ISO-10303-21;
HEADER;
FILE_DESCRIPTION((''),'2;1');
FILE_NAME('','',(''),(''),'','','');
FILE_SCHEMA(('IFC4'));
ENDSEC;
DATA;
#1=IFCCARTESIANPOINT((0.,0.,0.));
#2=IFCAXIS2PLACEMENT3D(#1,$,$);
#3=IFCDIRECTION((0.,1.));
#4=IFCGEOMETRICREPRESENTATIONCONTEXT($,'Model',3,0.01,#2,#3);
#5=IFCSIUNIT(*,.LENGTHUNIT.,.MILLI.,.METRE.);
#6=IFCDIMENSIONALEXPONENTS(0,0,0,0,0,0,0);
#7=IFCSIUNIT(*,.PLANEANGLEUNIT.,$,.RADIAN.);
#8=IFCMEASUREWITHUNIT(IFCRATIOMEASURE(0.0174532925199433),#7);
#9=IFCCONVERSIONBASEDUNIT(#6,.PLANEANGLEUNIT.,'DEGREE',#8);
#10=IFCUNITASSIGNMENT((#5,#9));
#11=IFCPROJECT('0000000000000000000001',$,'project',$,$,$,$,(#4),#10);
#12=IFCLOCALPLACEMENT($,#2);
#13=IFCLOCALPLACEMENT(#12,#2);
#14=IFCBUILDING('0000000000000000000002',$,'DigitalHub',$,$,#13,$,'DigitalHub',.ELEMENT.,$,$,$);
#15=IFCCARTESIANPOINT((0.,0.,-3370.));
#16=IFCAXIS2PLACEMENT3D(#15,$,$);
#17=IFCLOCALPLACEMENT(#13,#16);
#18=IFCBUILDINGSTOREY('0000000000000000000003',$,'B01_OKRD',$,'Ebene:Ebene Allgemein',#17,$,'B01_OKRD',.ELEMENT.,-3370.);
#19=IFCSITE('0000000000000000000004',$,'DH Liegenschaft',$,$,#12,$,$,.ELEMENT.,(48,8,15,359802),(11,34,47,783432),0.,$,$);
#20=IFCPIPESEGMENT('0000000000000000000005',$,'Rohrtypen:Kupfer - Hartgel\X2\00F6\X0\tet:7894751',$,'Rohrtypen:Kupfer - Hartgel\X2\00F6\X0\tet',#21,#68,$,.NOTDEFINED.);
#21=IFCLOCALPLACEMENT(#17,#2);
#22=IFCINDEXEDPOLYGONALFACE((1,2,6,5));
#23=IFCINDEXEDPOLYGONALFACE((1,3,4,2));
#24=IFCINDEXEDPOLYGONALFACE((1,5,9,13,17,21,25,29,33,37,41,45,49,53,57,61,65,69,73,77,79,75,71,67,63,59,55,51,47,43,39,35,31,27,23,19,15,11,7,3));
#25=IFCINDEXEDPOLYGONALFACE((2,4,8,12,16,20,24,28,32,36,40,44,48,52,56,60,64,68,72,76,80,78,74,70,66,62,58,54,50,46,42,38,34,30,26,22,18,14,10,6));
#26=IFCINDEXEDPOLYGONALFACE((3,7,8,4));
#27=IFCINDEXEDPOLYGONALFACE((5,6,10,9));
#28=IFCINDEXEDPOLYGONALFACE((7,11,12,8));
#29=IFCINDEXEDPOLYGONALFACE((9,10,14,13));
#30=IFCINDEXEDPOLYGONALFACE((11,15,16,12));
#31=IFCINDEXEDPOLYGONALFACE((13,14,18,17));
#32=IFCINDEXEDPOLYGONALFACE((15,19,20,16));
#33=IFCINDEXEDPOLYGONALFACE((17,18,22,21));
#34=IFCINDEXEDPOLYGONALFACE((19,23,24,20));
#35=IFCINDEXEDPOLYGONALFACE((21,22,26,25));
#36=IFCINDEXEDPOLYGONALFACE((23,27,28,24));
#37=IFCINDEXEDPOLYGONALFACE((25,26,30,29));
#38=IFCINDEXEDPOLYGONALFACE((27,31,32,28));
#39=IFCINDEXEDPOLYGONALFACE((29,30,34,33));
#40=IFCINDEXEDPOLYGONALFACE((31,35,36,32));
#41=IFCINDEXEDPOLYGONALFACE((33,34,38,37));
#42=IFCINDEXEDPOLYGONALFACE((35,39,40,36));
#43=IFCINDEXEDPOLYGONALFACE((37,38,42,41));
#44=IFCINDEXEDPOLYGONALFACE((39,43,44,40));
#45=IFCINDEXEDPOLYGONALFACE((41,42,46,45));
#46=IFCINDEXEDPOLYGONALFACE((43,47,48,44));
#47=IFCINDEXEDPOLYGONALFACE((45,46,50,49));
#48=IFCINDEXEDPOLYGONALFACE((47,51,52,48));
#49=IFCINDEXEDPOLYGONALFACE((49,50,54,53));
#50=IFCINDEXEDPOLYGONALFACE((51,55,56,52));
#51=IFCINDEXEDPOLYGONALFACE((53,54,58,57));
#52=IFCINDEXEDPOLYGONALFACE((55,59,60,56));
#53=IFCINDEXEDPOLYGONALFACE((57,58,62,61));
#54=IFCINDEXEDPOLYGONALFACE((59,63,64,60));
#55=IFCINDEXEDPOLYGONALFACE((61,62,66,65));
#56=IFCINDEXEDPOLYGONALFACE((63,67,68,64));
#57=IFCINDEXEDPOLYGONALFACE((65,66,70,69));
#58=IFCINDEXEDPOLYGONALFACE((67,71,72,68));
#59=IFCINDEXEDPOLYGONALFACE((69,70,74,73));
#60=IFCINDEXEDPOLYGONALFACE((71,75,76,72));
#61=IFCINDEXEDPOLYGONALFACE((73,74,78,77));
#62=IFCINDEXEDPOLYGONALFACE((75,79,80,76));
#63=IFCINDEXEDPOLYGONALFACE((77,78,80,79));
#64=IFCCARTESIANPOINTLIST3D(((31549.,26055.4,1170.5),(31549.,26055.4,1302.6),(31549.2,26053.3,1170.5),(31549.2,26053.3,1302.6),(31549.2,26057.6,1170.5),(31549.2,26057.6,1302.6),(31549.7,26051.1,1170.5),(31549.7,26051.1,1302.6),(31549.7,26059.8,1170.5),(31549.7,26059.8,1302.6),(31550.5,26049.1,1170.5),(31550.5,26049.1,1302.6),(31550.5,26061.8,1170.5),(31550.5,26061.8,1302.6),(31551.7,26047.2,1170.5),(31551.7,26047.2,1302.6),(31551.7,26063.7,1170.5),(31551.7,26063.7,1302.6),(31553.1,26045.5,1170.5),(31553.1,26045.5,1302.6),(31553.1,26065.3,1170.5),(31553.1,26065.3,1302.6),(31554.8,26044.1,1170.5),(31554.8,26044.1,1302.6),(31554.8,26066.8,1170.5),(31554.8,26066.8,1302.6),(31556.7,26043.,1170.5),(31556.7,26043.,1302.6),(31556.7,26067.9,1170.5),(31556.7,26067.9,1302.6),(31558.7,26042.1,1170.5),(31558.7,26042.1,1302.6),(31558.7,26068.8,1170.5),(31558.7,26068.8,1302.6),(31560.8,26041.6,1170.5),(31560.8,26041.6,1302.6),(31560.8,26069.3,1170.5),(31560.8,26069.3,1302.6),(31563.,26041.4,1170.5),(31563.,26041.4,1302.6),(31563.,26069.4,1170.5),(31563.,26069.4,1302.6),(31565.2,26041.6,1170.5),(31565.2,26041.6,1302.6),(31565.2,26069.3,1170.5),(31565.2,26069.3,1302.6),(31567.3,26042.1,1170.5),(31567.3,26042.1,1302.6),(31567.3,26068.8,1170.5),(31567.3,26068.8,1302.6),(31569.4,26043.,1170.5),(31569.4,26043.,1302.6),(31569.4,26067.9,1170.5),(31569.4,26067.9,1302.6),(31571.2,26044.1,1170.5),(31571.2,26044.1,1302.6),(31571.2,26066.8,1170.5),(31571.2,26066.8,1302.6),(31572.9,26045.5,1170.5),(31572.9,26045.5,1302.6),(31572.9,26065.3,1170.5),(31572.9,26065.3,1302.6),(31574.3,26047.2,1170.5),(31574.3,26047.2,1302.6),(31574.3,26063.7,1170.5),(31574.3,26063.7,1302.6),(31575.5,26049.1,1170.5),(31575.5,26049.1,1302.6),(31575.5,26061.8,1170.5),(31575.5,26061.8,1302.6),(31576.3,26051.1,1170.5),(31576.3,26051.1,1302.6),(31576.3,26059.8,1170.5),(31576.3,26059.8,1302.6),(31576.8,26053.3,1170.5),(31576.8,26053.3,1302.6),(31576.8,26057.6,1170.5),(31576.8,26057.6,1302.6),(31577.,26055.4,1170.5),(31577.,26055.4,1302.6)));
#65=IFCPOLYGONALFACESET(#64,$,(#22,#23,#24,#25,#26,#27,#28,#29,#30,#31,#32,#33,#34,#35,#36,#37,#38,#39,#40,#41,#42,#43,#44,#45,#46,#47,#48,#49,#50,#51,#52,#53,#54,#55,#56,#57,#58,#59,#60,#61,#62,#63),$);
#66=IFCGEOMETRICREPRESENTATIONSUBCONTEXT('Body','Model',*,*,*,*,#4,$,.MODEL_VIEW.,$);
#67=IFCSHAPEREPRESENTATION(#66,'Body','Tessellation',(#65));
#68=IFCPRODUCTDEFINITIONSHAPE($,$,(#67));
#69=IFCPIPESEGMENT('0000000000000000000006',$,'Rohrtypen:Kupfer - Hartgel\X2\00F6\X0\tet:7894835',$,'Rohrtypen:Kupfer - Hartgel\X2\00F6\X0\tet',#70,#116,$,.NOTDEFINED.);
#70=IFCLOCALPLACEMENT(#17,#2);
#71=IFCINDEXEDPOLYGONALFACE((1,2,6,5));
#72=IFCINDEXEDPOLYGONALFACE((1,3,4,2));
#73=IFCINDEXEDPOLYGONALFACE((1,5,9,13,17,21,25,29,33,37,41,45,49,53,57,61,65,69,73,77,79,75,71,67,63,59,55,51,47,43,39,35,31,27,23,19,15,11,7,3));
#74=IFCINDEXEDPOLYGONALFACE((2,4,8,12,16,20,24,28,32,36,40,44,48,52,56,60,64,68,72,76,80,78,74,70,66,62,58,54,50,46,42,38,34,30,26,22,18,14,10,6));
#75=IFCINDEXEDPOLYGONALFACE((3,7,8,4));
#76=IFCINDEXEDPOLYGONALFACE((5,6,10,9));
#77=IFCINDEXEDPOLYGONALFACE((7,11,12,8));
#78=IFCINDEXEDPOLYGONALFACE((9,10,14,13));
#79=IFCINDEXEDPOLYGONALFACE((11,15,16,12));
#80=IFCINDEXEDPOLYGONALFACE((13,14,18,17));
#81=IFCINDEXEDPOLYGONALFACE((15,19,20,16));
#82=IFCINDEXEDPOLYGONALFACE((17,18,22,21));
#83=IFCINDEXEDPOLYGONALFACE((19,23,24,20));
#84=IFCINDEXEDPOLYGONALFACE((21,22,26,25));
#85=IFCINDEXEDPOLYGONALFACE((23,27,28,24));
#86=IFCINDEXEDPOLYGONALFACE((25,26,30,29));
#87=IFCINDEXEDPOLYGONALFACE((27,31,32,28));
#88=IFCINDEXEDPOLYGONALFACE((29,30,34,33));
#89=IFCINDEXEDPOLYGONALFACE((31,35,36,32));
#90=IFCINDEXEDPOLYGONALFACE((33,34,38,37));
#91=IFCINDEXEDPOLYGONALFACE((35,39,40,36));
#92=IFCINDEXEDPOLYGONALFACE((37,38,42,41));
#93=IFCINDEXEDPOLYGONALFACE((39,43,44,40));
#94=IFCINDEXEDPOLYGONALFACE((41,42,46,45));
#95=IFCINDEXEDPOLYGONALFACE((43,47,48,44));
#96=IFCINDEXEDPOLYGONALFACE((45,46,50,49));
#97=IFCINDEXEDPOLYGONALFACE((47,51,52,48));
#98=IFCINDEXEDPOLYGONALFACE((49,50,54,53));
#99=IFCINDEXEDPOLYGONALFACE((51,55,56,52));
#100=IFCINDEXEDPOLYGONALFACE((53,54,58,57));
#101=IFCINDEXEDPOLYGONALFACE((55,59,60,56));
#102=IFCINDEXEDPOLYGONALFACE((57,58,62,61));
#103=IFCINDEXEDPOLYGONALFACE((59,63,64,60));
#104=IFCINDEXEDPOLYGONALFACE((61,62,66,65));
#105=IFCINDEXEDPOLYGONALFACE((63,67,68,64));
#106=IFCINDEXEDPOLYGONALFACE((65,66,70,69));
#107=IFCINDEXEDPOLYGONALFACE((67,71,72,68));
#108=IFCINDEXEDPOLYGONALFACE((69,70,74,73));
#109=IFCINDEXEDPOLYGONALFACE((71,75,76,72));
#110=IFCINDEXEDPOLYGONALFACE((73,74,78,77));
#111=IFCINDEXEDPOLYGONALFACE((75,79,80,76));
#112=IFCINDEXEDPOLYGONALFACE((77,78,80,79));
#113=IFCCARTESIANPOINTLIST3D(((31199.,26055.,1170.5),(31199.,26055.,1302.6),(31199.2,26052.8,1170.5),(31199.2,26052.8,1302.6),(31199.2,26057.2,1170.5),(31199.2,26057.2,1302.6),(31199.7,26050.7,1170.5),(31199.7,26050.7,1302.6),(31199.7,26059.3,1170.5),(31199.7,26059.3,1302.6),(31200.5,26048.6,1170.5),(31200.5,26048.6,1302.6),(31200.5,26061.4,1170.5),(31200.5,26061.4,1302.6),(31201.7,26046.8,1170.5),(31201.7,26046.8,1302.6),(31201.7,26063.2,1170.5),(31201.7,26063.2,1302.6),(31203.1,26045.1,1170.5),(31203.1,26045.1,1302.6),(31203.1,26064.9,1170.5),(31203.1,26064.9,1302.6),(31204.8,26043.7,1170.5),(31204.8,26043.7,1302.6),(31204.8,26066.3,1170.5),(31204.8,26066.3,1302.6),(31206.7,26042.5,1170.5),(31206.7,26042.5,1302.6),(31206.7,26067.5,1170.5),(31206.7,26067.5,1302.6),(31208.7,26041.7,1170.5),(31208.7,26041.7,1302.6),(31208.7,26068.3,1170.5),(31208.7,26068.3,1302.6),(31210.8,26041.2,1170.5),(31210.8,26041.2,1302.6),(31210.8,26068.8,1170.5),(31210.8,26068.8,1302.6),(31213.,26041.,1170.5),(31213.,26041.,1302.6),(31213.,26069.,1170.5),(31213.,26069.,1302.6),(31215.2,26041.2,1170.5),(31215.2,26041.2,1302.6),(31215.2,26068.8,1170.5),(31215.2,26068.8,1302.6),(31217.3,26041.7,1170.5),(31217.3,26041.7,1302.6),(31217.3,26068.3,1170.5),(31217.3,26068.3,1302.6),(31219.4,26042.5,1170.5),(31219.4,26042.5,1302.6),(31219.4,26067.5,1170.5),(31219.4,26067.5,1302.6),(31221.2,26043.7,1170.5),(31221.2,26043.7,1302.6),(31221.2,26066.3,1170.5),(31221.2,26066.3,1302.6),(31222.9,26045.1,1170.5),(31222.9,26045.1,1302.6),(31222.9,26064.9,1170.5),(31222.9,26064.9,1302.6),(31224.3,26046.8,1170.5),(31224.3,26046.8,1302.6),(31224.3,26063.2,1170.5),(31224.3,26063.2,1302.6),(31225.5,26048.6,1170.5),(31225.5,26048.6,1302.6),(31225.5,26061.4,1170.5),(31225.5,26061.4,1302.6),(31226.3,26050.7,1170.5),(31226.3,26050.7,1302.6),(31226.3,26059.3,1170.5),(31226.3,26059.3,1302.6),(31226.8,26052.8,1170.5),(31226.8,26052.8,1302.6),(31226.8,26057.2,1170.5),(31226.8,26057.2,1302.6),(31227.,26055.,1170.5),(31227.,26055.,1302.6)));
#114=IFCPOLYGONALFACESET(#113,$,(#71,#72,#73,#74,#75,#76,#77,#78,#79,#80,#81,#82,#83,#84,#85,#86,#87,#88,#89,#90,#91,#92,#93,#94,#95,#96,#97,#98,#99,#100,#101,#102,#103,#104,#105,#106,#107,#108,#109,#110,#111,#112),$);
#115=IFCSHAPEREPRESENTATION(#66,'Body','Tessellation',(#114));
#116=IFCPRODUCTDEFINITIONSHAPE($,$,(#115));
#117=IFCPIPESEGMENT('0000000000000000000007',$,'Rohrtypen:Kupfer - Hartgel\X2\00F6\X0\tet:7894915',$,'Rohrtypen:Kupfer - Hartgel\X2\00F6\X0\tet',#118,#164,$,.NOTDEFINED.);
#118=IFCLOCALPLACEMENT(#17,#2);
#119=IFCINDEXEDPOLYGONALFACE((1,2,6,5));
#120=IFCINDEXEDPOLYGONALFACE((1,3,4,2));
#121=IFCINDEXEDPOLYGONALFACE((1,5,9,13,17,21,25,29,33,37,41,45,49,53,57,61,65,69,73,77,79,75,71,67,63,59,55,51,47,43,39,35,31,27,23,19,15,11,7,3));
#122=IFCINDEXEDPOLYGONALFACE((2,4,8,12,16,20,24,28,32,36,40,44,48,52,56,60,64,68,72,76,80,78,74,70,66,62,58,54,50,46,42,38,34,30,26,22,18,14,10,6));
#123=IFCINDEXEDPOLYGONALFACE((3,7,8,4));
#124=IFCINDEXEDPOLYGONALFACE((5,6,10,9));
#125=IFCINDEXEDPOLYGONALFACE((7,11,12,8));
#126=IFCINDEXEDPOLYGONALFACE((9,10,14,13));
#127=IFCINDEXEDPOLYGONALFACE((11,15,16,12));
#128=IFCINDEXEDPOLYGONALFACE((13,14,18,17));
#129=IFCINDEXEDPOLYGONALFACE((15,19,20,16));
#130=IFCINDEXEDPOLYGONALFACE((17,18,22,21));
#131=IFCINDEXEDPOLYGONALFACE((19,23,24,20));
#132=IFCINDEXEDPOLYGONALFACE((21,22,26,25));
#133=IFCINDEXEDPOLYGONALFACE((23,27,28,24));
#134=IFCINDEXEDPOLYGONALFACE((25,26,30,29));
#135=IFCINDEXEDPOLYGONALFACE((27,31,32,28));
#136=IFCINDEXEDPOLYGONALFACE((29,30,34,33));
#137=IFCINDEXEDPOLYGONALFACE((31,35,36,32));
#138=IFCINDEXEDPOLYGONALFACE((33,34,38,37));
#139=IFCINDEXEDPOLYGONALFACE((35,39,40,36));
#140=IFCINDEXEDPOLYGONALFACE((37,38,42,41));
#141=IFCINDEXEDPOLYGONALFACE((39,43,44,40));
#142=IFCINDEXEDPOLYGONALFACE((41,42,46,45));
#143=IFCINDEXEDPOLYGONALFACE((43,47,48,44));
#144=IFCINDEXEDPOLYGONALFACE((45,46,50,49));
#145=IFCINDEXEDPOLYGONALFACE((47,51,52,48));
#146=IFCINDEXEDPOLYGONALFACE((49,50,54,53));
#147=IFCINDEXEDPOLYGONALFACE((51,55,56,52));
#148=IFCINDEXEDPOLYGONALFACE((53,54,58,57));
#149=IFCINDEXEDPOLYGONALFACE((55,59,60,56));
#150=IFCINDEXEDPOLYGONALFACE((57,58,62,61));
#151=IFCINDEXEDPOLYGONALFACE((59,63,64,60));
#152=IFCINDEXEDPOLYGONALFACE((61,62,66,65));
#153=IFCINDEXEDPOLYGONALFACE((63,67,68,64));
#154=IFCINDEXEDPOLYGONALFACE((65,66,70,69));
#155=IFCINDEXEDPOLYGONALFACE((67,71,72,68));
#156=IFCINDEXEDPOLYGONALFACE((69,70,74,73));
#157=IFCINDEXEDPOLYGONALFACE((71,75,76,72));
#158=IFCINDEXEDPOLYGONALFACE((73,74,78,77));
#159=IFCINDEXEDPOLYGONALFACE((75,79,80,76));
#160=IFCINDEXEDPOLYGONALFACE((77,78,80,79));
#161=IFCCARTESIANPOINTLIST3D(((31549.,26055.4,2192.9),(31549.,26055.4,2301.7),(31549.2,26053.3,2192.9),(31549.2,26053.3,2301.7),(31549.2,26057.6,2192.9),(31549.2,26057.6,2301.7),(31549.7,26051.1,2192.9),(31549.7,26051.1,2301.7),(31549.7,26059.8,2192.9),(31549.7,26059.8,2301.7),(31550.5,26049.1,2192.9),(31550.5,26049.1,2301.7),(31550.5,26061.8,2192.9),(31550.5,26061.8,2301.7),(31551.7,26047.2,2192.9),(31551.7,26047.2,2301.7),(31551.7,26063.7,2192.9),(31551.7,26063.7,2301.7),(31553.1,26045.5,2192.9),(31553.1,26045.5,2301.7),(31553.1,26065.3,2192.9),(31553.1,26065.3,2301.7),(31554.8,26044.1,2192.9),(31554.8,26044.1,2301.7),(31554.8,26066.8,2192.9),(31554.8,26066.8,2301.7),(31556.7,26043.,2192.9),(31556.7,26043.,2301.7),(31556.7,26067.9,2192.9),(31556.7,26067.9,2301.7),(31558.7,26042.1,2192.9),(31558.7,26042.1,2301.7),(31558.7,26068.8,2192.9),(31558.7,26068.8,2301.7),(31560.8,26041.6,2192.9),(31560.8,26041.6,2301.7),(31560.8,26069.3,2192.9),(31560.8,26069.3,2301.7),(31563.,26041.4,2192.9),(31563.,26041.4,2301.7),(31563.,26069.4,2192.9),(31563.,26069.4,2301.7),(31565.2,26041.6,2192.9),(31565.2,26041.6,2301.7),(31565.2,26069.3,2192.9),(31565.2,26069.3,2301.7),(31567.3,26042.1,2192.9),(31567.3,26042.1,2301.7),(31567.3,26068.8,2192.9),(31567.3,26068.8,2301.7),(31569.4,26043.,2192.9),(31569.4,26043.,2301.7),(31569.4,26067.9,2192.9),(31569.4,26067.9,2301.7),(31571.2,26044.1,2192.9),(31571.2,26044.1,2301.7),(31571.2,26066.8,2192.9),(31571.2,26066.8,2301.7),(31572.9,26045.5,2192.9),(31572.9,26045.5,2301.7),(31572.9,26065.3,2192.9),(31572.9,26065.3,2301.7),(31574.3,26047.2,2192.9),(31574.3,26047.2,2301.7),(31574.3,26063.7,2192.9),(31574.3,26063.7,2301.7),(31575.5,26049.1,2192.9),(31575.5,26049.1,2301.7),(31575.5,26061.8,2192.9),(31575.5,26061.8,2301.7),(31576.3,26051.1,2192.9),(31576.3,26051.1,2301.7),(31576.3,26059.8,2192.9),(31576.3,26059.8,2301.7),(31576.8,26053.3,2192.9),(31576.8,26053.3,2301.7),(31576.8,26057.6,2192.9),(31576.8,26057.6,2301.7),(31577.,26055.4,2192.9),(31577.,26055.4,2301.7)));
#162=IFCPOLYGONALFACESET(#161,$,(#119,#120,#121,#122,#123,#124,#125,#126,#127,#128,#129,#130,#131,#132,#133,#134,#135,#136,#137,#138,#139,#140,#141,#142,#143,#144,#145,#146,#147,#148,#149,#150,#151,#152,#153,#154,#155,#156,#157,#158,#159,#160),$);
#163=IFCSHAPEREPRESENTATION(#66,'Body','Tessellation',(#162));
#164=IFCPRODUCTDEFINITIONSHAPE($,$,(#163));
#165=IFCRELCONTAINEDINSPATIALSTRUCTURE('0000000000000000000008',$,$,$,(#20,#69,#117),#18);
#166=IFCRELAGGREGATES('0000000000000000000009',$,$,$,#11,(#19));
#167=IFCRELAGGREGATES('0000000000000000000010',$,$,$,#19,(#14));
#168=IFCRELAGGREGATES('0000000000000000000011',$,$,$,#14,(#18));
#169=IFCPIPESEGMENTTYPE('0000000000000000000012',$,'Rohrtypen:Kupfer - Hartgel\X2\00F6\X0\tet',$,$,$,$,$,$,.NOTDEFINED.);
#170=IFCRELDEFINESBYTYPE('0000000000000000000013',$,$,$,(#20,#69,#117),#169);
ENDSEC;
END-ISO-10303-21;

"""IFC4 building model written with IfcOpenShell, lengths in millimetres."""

from ifc_helpers import new_model, entity, si_unit, converted_unit, direction, frame, origin, place, context, subcontext, project, spatial, indexed_curve, outline, extrude, type_object, element, save


model = new_model("IFC4")

# Units and contexts
model_context = context("Model", 3, precision=0.01, world=origin(), true_north=direction((0.0, 1.0)))
body_context = subcontext(model_context, "Body", "Model", "MODEL_VIEW")
ifc_project = project(units=[si_unit("LENGTHUNIT", "METRE", prefix="MILLI"), converted_unit("PLANEANGLEUNIT", "DEGREE", entity("IfcRatioMeasure", 0.0174532925199433), si_unit("PLANEANGLEUNIT", "RADIAN"), dimensions=[0, 0, 0, 0, 0, 0, 0])], contexts=[model_context])

# Site, building, storey
site_placement = place(None, origin())
site = spatial("IfcSite", under=ifc_project, at=site_placement, Name="DH Liegenschaft", CompositionType="ELEMENT", RefLatitude=(48, 8, 15, 359802), RefLongitude=(11, 34, 47, 783432), RefElevation=0.0)
building_placement = place(site_placement, origin())
building = spatial("IfcBuilding", under=site, at=building_placement, Name="DigitalHub", LongName="DigitalHub", CompositionType="ELEMENT")
storey_placement = place(building_placement, frame((0.0, 0.0, -3370.0)))
storey = spatial("IfcBuildingStorey", under=building, at=storey_placement, Name="B01_OKRD", ObjectType="Ebene:Ebene Allgemein", LongName="B01_OKRD", CompositionType="ELEMENT", Elevation=-3370.0)

# Pipe segments
pipe_segment_type = type_object("IfcPipeSegmentType", Name="Rohrtypen:Kupfer - Hartgelötet", PredefinedType="NOTDEFINED")
pipe_segment_1_placement = place(storey_placement, frame((31547.4, 26039.9, 1170.5)))
element("IfcPipeSegment", 1, at=pipe_segment_1_placement, inside=storey, type_object=pipe_segment_type, Name="Rohrtypen:Kupfer - Hartgelötet:7894751", ObjectType="Rohrtypen:Kupfer - Hartgelötet", PredefinedType="NOTDEFINED", context=body_context, shape_type="SweptSolid", body=[
    extrude(outline(indexed_curve([(14.0, 0.0), (13.8, 2.2), (13.3, 4.3), (12.5, 6.4), (11.3, 8.2), (9.9, 9.9), (8.2, 11.3), (6.4, 12.5), (4.3, 13.3), (2.2, 13.8), (0.0, 14.0), (-2.2, 13.8), (-4.3, 13.3), (-6.4, 12.5), (-8.2, 11.3), (-9.9, 9.9), (-11.3, 8.2), (-12.5, 6.4), (-13.3, 4.3), (-13.8, 2.2), (-14.0, 0.0), (-13.8, -2.2), (-13.3, -4.3), (-12.5, -6.4), (-11.3, -8.2), (-9.9, -9.9), (-8.2, -11.3), (-6.4, -12.5), (-4.3, -13.3), (-2.2, -13.8), (0.0, -14.0), (2.2, -13.8), (4.3, -13.3), (6.4, -12.5), (8.2, -11.3), (9.9, -9.9), (11.3, -8.2), (12.5, -6.4), (13.3, -4.3), (13.8, -2.2), (14.0, 0.0)], self_intersect=False)), frame((15.6, 15.6, 0.0), z_axis=(0.0, 0.0, 1.0), x_axis=(-1.0, 0.0, 0.0)), (0.0, 0.0, 1.0), 132.1),
])
pipe_segment_2_placement = place(storey_placement, frame((31197.4, 26039.4, 1170.5)))
element("IfcPipeSegment", 2, at=pipe_segment_2_placement, inside=storey, type_object=pipe_segment_type, Name="Rohrtypen:Kupfer - Hartgelötet:7894835", ObjectType="Rohrtypen:Kupfer - Hartgelötet", PredefinedType="NOTDEFINED", context=body_context, shape_type="SweptSolid", body=[
    extrude(outline(indexed_curve([(14.0, 0.0), (13.8, 2.2), (13.3, 4.3), (12.5, 6.4), (11.3, 8.2), (9.9, 9.9), (8.2, 11.3), (6.4, 12.5), (4.3, 13.3), (2.2, 13.8), (0.0, 14.0), (-2.2, 13.8), (-4.3, 13.3), (-6.4, 12.5), (-8.2, 11.3), (-9.9, 9.9), (-11.3, 8.2), (-12.5, 6.4), (-13.3, 4.3), (-13.8, 2.2), (-14.0, 0.0), (-13.8, -2.2), (-13.3, -4.3), (-12.5, -6.4), (-11.3, -8.2), (-9.9, -9.9), (-8.2, -11.3), (-6.4, -12.5), (-4.3, -13.3), (-2.2, -13.8), (0.0, -14.0), (2.2, -13.8), (4.3, -13.3), (6.4, -12.5), (8.2, -11.3), (9.9, -9.9), (11.3, -8.2), (12.5, -6.4), (13.3, -4.3), (13.8, -2.2), (14.0, 0.0)], self_intersect=False)), frame((15.6, 15.6, 0.0), z_axis=(0.0, 0.0, 1.0), x_axis=(-1.0, 0.0, 0.0)), (0.0, 0.0, 1.0), 132.1),
])
pipe_segment_3_placement = place(storey_placement, frame((31547.4, 26039.9, 2192.9)))
element("IfcPipeSegment", 3, at=pipe_segment_3_placement, inside=storey, type_object=pipe_segment_type, Name="Rohrtypen:Kupfer - Hartgelötet:7894915", ObjectType="Rohrtypen:Kupfer - Hartgelötet", PredefinedType="NOTDEFINED", context=body_context, shape_type="SweptSolid", body=[
    extrude(outline(indexed_curve([(14.0, 0.0), (13.8, 2.2), (13.3, 4.3), (12.5, 6.4), (11.3, 8.2), (9.9, 9.9), (8.2, 11.3), (6.4, 12.5), (4.3, 13.3), (2.2, 13.8), (0.0, 14.0), (-2.2, 13.8), (-4.3, 13.3), (-6.4, 12.5), (-8.2, 11.3), (-9.9, 9.9), (-11.3, 8.2), (-12.5, 6.4), (-13.3, 4.3), (-13.8, 2.2), (-14.0, 0.0), (-13.8, -2.2), (-13.3, -4.3), (-12.5, -6.4), (-11.3, -8.2), (-9.9, -9.9), (-8.2, -11.3), (-6.4, -12.5), (-4.3, -13.3), (-2.2, -13.8), (0.0, -14.0), (2.2, -13.8), (4.3, -13.3), (6.4, -12.5), (8.2, -11.3), (9.9, -9.9), (11.3, -8.2), (12.5, -6.4), (13.3, -4.3), (13.8, -2.2), (14.0, 0.0)], self_intersect=False)), frame((15.6, 15.6, 0.0), z_axis=(0.0, 0.0, 1.0), x_axis=(-1.0, 0.0, 0.0)), (0.0, 0.0, 1.0), 108.7),
])

save(model, "model.ifc")
